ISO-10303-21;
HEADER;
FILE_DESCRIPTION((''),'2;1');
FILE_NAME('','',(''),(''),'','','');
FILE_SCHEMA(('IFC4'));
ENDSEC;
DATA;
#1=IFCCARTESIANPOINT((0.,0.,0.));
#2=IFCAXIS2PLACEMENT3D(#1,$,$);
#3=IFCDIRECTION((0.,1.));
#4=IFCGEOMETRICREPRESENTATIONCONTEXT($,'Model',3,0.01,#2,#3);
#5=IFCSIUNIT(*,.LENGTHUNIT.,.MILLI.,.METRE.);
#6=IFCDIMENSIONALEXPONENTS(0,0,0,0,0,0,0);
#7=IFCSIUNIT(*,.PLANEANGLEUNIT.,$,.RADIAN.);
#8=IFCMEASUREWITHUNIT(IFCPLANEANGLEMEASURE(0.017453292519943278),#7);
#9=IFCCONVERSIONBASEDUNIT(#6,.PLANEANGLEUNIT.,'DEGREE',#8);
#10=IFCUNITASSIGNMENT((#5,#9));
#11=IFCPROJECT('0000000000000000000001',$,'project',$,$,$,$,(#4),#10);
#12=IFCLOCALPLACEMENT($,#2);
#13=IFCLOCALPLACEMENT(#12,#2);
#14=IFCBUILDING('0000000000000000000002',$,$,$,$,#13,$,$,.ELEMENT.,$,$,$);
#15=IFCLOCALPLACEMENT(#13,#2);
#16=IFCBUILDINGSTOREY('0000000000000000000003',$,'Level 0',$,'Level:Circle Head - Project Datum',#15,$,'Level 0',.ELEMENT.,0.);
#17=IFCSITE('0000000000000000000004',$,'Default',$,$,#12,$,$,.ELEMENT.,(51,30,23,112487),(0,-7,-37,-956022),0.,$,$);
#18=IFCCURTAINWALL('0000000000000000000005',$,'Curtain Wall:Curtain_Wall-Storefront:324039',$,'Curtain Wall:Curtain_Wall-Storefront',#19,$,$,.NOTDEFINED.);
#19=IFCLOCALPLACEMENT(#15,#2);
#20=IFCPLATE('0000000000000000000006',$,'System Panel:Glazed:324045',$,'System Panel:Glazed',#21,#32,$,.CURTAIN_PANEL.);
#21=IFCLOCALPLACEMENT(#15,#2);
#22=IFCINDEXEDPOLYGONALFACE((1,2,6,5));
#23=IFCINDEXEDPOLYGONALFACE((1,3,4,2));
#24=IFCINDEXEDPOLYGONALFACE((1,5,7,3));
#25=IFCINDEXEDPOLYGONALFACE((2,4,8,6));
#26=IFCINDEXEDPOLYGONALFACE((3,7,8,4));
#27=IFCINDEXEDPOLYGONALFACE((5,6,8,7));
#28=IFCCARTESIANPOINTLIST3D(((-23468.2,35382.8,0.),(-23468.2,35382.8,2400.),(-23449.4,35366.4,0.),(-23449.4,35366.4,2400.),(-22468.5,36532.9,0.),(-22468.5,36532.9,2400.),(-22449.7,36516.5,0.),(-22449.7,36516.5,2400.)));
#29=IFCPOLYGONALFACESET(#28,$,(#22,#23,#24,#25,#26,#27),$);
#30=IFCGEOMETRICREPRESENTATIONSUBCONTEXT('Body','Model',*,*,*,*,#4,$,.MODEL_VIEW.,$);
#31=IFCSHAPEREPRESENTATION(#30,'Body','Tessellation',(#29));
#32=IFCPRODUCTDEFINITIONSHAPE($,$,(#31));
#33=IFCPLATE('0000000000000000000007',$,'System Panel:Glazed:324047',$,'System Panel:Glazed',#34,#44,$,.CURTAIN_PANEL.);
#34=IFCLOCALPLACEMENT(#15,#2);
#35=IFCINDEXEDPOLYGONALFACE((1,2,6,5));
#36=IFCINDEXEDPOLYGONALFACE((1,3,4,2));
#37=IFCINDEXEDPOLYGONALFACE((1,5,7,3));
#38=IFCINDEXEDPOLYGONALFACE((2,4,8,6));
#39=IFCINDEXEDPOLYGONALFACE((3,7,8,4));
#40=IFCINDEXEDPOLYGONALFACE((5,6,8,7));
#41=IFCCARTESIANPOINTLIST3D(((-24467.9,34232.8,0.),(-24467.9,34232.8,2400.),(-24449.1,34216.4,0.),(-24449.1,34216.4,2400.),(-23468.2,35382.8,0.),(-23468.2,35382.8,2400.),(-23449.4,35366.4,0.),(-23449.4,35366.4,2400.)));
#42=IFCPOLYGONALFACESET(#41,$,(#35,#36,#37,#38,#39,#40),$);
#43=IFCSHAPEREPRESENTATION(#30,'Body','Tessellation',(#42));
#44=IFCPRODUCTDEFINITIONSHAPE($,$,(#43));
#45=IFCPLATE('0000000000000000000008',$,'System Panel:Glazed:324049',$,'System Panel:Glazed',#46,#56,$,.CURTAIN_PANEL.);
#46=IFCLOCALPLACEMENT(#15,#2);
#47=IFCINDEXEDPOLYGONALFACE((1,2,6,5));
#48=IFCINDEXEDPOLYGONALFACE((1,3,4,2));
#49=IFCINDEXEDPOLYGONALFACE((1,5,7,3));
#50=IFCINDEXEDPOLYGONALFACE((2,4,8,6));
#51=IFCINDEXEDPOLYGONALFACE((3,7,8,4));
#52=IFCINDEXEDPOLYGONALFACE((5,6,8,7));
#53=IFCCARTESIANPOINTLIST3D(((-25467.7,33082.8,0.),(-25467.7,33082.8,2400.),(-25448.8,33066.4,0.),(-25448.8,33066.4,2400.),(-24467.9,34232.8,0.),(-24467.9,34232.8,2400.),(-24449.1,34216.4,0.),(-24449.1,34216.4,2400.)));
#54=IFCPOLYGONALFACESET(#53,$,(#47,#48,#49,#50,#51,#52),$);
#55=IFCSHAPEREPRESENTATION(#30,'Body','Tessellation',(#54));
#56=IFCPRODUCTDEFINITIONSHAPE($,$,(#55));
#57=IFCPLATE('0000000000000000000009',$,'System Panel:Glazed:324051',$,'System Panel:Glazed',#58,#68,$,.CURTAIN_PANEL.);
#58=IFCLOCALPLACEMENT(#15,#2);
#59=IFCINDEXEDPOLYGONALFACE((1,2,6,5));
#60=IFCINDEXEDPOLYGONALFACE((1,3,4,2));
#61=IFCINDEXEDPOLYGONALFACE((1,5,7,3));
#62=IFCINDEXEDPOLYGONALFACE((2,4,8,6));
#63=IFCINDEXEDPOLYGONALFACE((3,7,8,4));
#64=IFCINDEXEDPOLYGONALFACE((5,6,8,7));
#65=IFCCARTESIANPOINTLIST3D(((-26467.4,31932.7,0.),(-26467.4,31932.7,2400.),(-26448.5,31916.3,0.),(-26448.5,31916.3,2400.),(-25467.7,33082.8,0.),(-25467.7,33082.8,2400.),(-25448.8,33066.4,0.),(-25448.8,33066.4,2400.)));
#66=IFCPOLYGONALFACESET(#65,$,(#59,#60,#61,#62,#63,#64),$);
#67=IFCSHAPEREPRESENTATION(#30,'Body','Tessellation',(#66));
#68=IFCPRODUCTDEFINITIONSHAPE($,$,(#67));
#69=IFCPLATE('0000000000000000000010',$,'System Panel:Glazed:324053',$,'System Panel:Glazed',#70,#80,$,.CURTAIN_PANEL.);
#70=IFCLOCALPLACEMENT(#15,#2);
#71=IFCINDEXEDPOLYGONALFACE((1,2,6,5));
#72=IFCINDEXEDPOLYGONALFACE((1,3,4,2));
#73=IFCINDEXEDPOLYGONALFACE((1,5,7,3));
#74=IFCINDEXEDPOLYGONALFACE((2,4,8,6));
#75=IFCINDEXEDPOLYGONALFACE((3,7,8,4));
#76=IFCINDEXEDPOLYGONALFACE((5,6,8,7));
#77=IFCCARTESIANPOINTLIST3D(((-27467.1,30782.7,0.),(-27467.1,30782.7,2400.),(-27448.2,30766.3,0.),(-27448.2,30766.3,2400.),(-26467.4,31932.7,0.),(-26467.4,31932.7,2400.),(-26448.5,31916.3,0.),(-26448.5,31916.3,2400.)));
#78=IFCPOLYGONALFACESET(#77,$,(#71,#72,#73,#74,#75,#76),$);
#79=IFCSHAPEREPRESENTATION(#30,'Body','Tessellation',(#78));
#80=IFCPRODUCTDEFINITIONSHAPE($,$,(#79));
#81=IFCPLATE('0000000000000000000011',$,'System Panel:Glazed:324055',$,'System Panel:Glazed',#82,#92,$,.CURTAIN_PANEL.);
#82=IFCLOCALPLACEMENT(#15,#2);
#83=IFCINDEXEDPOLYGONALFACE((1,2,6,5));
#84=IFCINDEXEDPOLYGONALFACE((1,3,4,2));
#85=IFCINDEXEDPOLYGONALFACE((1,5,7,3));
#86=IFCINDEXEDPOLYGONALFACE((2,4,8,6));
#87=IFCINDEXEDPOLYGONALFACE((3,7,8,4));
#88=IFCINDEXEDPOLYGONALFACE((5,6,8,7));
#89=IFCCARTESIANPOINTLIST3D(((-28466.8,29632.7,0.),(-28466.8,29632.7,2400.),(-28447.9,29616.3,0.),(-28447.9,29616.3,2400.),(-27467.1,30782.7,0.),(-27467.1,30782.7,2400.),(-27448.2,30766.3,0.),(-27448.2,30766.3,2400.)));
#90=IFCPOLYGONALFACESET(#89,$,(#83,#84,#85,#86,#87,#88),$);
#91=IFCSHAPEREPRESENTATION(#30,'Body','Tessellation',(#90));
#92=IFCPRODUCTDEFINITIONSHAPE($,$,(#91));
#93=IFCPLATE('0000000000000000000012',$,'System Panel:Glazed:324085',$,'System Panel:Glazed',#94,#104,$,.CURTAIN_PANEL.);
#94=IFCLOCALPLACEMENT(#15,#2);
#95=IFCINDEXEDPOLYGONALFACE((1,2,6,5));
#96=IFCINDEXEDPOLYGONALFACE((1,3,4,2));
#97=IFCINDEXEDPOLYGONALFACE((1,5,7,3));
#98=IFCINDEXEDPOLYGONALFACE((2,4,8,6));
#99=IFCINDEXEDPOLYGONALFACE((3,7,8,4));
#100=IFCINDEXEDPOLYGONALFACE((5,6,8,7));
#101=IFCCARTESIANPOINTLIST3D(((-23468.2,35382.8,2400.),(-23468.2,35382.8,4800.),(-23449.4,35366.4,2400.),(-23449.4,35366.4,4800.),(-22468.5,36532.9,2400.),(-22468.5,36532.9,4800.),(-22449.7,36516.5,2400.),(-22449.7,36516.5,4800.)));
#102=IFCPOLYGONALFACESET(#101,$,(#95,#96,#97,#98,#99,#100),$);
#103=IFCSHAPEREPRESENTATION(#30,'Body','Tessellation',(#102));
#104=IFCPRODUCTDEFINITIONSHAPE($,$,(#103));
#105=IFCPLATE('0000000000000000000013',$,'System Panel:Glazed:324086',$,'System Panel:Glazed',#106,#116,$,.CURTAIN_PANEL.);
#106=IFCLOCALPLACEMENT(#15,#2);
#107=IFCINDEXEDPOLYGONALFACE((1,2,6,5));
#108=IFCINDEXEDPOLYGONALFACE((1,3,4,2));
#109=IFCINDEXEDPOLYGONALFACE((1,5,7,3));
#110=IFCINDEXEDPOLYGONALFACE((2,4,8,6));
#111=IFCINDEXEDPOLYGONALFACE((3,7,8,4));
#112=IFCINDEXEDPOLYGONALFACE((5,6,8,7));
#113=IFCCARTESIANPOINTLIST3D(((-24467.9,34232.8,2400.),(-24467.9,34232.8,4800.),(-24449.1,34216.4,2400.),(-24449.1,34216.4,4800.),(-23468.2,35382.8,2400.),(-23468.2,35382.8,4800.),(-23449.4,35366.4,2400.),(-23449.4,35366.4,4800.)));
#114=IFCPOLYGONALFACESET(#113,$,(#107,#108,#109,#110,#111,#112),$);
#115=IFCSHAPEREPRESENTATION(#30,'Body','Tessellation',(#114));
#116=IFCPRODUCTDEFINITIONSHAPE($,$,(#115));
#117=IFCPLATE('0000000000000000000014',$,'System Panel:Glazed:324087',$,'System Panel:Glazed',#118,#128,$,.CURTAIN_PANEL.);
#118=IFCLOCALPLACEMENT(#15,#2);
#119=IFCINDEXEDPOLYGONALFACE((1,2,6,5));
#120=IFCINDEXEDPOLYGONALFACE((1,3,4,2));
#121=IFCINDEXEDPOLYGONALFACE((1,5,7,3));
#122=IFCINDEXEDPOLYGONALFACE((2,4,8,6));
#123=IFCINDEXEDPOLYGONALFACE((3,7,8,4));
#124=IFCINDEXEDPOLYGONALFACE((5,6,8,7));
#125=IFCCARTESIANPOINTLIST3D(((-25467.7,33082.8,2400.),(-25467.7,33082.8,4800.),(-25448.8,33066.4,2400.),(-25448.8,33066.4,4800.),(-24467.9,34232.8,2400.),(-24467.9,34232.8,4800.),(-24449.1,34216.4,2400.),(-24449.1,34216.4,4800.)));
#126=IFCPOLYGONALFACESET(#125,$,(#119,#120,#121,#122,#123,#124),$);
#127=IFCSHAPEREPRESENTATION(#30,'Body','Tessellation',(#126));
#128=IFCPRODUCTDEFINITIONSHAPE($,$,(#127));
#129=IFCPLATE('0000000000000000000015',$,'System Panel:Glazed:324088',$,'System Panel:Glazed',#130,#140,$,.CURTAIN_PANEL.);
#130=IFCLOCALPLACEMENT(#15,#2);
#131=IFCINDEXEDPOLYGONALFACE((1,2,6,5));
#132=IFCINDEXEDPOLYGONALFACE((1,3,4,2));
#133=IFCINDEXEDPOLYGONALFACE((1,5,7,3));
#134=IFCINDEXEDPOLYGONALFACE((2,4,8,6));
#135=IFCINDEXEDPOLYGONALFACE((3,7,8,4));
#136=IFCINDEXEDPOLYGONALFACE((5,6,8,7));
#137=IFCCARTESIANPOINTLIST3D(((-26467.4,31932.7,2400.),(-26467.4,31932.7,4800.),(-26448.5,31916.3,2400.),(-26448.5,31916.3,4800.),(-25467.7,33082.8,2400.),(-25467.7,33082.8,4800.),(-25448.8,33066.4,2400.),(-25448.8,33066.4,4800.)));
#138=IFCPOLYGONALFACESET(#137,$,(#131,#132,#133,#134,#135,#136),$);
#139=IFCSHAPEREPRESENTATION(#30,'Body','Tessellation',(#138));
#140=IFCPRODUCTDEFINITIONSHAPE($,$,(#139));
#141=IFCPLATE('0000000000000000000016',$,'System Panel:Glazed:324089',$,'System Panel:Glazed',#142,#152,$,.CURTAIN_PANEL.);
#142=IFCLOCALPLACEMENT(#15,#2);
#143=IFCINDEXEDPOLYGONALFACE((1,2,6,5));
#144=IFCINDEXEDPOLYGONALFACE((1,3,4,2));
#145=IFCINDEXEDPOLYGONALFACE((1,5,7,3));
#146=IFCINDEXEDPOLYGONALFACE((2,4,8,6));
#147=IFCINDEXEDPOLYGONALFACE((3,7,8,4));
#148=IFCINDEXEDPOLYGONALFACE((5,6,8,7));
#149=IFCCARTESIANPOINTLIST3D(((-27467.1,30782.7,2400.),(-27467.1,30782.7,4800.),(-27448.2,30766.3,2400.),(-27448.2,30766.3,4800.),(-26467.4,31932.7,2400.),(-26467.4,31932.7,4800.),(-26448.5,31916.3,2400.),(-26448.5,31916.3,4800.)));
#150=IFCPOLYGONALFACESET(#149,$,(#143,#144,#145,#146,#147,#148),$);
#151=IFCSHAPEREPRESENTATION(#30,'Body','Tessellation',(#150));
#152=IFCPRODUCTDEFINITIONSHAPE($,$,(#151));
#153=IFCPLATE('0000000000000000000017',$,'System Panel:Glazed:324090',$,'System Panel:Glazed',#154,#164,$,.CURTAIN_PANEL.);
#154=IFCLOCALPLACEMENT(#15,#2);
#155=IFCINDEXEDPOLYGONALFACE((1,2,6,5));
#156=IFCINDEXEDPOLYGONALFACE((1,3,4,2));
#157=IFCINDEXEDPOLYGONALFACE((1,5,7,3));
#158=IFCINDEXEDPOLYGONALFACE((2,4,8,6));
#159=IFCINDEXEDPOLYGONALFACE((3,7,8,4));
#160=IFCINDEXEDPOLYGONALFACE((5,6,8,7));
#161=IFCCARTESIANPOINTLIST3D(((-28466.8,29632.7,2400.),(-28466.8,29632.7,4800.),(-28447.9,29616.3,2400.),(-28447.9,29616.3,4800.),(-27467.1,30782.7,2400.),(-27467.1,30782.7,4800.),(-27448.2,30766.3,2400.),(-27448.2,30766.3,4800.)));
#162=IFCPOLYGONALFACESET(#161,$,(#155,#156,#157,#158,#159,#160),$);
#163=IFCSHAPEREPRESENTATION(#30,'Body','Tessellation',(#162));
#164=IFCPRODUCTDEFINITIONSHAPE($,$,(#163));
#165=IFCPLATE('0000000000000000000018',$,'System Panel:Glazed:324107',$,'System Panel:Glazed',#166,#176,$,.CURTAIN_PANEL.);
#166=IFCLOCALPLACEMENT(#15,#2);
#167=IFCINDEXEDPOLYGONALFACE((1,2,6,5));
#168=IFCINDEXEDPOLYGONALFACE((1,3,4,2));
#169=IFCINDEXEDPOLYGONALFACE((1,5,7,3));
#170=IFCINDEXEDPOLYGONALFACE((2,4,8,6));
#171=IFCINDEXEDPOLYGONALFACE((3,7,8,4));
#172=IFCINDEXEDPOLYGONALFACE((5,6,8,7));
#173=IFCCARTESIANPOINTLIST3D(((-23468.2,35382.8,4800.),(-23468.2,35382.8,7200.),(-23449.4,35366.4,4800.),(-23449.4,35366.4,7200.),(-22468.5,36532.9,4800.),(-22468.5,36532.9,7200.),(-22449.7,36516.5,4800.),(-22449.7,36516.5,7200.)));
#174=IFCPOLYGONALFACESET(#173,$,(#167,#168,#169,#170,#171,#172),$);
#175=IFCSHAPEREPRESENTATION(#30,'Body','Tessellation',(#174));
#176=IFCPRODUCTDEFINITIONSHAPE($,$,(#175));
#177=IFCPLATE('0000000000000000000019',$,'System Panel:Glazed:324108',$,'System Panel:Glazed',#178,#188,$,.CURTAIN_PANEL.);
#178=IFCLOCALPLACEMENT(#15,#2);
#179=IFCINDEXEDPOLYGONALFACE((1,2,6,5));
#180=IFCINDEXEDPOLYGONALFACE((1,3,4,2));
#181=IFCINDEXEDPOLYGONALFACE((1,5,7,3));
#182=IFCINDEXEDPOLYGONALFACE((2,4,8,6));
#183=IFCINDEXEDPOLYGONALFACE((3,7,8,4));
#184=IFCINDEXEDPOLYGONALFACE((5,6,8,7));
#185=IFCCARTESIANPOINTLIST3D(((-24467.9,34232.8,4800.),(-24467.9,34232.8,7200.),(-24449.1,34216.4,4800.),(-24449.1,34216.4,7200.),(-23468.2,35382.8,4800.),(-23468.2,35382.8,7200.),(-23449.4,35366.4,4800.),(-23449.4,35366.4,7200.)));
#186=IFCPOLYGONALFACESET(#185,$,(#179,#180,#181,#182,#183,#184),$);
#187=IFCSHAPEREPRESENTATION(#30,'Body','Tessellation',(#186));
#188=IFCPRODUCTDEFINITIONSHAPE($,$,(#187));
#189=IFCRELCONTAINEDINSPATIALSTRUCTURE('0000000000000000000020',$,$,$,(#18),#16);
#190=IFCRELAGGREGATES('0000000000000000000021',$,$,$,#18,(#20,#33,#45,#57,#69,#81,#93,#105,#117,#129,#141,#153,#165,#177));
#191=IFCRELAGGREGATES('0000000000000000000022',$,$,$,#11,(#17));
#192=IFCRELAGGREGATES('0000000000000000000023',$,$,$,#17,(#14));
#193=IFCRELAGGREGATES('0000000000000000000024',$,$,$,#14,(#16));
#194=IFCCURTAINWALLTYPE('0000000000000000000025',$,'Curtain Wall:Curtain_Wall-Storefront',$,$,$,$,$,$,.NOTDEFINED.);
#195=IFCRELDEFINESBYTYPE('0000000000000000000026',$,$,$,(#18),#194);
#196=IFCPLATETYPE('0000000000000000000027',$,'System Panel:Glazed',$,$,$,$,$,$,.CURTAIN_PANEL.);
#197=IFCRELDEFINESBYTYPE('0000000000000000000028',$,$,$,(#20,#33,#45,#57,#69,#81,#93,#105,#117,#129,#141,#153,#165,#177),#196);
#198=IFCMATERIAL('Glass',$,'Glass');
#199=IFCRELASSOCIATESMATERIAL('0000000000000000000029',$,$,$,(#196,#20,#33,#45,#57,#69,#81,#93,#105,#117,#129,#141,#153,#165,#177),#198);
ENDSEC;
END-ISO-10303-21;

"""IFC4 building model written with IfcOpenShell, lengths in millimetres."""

from ifc_helpers import new_model, entity, si_unit, converted_unit, direction, frame, origin, place, context, subcontext, project, spatial, indexed_curve, outline, extrude, source, transform, mapped, material, type_object, type_shapes, element, aggregate, save


model = new_model("IFC4")

# Units and contexts
model_context = context("Model", 3, precision=0.01, world=origin(), true_north=direction((0.0, 1.0)))
body_context = subcontext(model_context, "Body", "Model", "MODEL_VIEW")
ifc_project = project(units=[si_unit("LENGTHUNIT", "METRE", prefix="MILLI"), converted_unit("PLANEANGLEUNIT", "DEGREE", entity("IfcPlaneAngleMeasure", 0.017453292519943278), si_unit("PLANEANGLEUNIT", "RADIAN"), dimensions=[0, 0, 0, 0, 0, 0, 0])], contexts=[model_context])

# Site, building, storey
site_placement = place(None, origin())
site = spatial("IfcSite", under=ifc_project, at=site_placement, Name="Default", CompositionType="ELEMENT", RefLatitude=(51, 30, 23, 112487), RefLongitude=(0, -7, -37, -956022), RefElevation=0.0)
building_placement = place(site_placement, origin())
building = spatial("IfcBuilding", under=site, at=building_placement, CompositionType="ELEMENT")
storey_placement = place(building_placement, origin())
storey = spatial("IfcBuildingStorey", under=building, at=storey_placement, Name="Level 0", ObjectType="Level:Circle Head - Project Datum", LongName="Level 0", CompositionType="ELEMENT", Elevation=0.0)

# Curtain wall, plates
curtain_wall_type = type_object("IfcCurtainWallType", Name="Curtain Wall:Curtain_Wall-Storefront", PredefinedType="NOTDEFINED")
curtain_wall_placement = place(storey_placement, origin())
curtain_wall = element("IfcCurtainWall", 1, at=curtain_wall_placement, inside=storey, type_object=curtain_wall_type, Name="Curtain Wall:Curtain_Wall-Storefront:324039", ObjectType="Curtain Wall:Curtain_Wall-Storefront", PredefinedType="NOTDEFINED")
ifc_material = material(Name="Glass", Category="Glass")
plate_type_1 = type_object("IfcPlateType", Name="System Panel:Glazed", PredefinedType="CURTAIN_PANEL", material=ifc_material)
shared_shape_1 = source(origin(), body_context, "Body", "SweptSolid", [
    extrude(outline(indexed_curve([(-12.5, -761.9), (12.5, -761.9), (12.5, 761.9), (-12.5, 761.9), (-12.5, -761.9)], self_intersect=False)), frame((0.0, 37.0, 0.0), z_axis=(0.0, 0.0, 1.0), x_axis=(0.0, 1.0, 0.0)), (0.0, 0.0, 1.0), 2400.0),
])
type_shapes(plate_type_1, [shared_shape_1])
plate_1_placement = place(curtain_wall_placement, frame((-22986.9, 35973.9, 0.0), z_axis=(0.0, 0.0, 1.0), x_axis=(-0.656059, -0.75471, 0.0)))
plate_1 = element("IfcPlate", 2, at=plate_1_placement, type_object=plate_type_1, material=ifc_material, Name="System Panel:Glazed:324045", ObjectType="System Panel:Glazed", PredefinedType="CURTAIN_PANEL", context=body_context, shape_type="MappedRepresentation", body=[
    mapped(shared_shape_1, transform((0.0, 0.0, 0.0), scale=1.0)),
])
plate_2_placement = place(curtain_wall_placement, frame((-23986.6, 34823.9, 0.0), z_axis=(0.0, 0.0, 1.0), x_axis=(-0.656059, -0.75471, 0.0)))
plate_2 = element("IfcPlate", 3, at=plate_2_placement, type_object=plate_type_1, material=ifc_material, Name="System Panel:Glazed:324047", ObjectType="System Panel:Glazed", PredefinedType="CURTAIN_PANEL", context=body_context, shape_type="MappedRepresentation", body=[
    mapped(shared_shape_1, transform((0.0, 0.0, 0.0), scale=1.0)),
])
plate_3_placement = place(curtain_wall_placement, frame((-24986.3, 33673.9, 0.0), z_axis=(0.0, 0.0, 1.0), x_axis=(-0.656059, -0.75471, 0.0)))
plate_3 = element("IfcPlate", 4, at=plate_3_placement, type_object=plate_type_1, material=ifc_material, Name="System Panel:Glazed:324049", ObjectType="System Panel:Glazed", PredefinedType="CURTAIN_PANEL", context=body_context, shape_type="MappedRepresentation", body=[
    mapped(shared_shape_1, transform((0.0, 0.0, 0.0), scale=1.0)),
])
plate_4_placement = place(curtain_wall_placement, frame((-25986.0, 32523.8, 0.0), z_axis=(0.0, 0.0, 1.0), x_axis=(-0.656059, -0.75471, 0.0)))
plate_4 = element("IfcPlate", 5, at=plate_4_placement, type_object=plate_type_1, material=ifc_material, Name="System Panel:Glazed:324051", ObjectType="System Panel:Glazed", PredefinedType="CURTAIN_PANEL", context=body_context, shape_type="MappedRepresentation", body=[
    mapped(shared_shape_1, transform((0.0, 0.0, 0.0), scale=1.0)),
])
plate_5_placement = place(curtain_wall_placement, frame((-26985.7, 31373.8, 0.0), z_axis=(0.0, 0.0, 1.0), x_axis=(-0.656059, -0.75471, 0.0)))
plate_5 = element("IfcPlate", 6, at=plate_5_placement, type_object=plate_type_1, material=ifc_material, Name="System Panel:Glazed:324053", ObjectType="System Panel:Glazed", PredefinedType="CURTAIN_PANEL", context=body_context, shape_type="MappedRepresentation", body=[
    mapped(shared_shape_1, transform((0.0, 0.0, 0.0), scale=1.0)),
])
plate_6_placement = place(curtain_wall_placement, frame((-27985.4, 30223.8, 0.0), z_axis=(0.0, 0.0, 1.0), x_axis=(-0.656059, -0.75471, 0.0)))
plate_6 = element("IfcPlate", 7, at=plate_6_placement, type_object=plate_type_1, material=ifc_material, Name="System Panel:Glazed:324055", ObjectType="System Panel:Glazed", PredefinedType="CURTAIN_PANEL", context=body_context, shape_type="MappedRepresentation", body=[
    mapped(shared_shape_1, transform((0.0, 0.0, 0.0), scale=1.0)),
])
plate_7_placement = place(curtain_wall_placement, frame((-22986.9, 35973.9, 2400.0), z_axis=(0.0, 0.0, 1.0), x_axis=(-0.656059, -0.75471, 0.0)))
plate_7 = element("IfcPlate", 8, at=plate_7_placement, type_object=plate_type_1, material=ifc_material, Name="System Panel:Glazed:324085", ObjectType="System Panel:Glazed", PredefinedType="CURTAIN_PANEL", context=body_context, shape_type="MappedRepresentation", body=[
    mapped(shared_shape_1, transform((0.0, 0.0, 0.0), scale=1.0)),
])
plate_8_placement = place(curtain_wall_placement, frame((-23986.6, 34823.9, 2400.0), z_axis=(0.0, 0.0, 1.0), x_axis=(-0.656059, -0.75471, 0.0)))
plate_8 = element("IfcPlate", 9, at=plate_8_placement, type_object=plate_type_1, material=ifc_material, Name="System Panel:Glazed:324086", ObjectType="System Panel:Glazed", PredefinedType="CURTAIN_PANEL", context=body_context, shape_type="MappedRepresentation", body=[
    mapped(shared_shape_1, transform((0.0, 0.0, 0.0), scale=1.0)),
])
plate_9_placement = place(curtain_wall_placement, frame((-24986.3, 33673.9, 2400.0), z_axis=(0.0, 0.0, 1.0), x_axis=(-0.656059, -0.75471, 0.0)))
plate_9 = element("IfcPlate", 10, at=plate_9_placement, type_object=plate_type_1, material=ifc_material, Name="System Panel:Glazed:324087", ObjectType="System Panel:Glazed", PredefinedType="CURTAIN_PANEL", context=body_context, shape_type="MappedRepresentation", body=[
    mapped(shared_shape_1, transform((0.0, 0.0, 0.0), scale=1.0)),
])
plate_10_placement = place(curtain_wall_placement, frame((-25986.0, 32523.8, 2400.0), z_axis=(0.0, 0.0, 1.0), x_axis=(-0.656059, -0.75471, 0.0)))
plate_10 = element("IfcPlate", 11, at=plate_10_placement, type_object=plate_type_1, material=ifc_material, Name="System Panel:Glazed:324088", ObjectType="System Panel:Glazed", PredefinedType="CURTAIN_PANEL", context=body_context, shape_type="MappedRepresentation", body=[
    mapped(shared_shape_1, transform((0.0, 0.0, 0.0), scale=1.0)),
])
plate_11_placement = place(curtain_wall_placement, frame((-26985.7, 31373.8, 2400.0), z_axis=(0.0, 0.0, 1.0), x_axis=(-0.656059, -0.75471, 0.0)))
plate_11 = element("IfcPlate", 12, at=plate_11_placement, type_object=plate_type_1, material=ifc_material, Name="System Panel:Glazed:324089", ObjectType="System Panel:Glazed", PredefinedType="CURTAIN_PANEL", context=body_context, shape_type="MappedRepresentation", body=[
    mapped(shared_shape_1, transform((0.0, 0.0, 0.0), scale=1.0)),
])
plate_12_placement = place(curtain_wall_placement, frame((-27985.4, 30223.8, 2400.0), z_axis=(0.0, 0.0, 1.0), x_axis=(-0.656059, -0.75471, 0.0)))
plate_12 = element("IfcPlate", 13, at=plate_12_placement, type_object=plate_type_1, material=ifc_material, Name="System Panel:Glazed:324090", ObjectType="System Panel:Glazed", PredefinedType="CURTAIN_PANEL", context=body_context, shape_type="MappedRepresentation", body=[
    mapped(shared_shape_1, transform((0.0, 0.0, 0.0), scale=1.0)),
])
plate_13_placement = place(curtain_wall_placement, frame((-22986.9, 35973.9, 4800.0), z_axis=(0.0, 0.0, 1.0), x_axis=(-0.656059, -0.75471, 0.0)))
plate_13 = element("IfcPlate", 14, at=plate_13_placement, type_object=plate_type_1, material=ifc_material, Name="System Panel:Glazed:324107", ObjectType="System Panel:Glazed", PredefinedType="CURTAIN_PANEL", context=body_context, shape_type="MappedRepresentation", body=[
    mapped(shared_shape_1, transform((0.0, 0.0, 0.0), scale=1.0)),
])
plate_14_placement = place(curtain_wall_placement, frame((-23986.6, 34823.9, 4800.0), z_axis=(0.0, 0.0, 1.0), x_axis=(-0.656059, -0.75471, 0.0)))
plate_14 = element("IfcPlate", 15, at=plate_14_placement, type_object=plate_type_1, material=ifc_material, Name="System Panel:Glazed:324108", ObjectType="System Panel:Glazed", PredefinedType="CURTAIN_PANEL", context=body_context, shape_type="MappedRepresentation", body=[
    mapped(shared_shape_1, transform((0.0, 0.0, 0.0), scale=1.0)),
])
aggregate(curtain_wall, [plate_1, plate_2, plate_3, plate_4, plate_5, plate_6, plate_7, plate_8, plate_9, plate_10, plate_11, plate_12, plate_13, plate_14])

save(model, "model.ifc")
